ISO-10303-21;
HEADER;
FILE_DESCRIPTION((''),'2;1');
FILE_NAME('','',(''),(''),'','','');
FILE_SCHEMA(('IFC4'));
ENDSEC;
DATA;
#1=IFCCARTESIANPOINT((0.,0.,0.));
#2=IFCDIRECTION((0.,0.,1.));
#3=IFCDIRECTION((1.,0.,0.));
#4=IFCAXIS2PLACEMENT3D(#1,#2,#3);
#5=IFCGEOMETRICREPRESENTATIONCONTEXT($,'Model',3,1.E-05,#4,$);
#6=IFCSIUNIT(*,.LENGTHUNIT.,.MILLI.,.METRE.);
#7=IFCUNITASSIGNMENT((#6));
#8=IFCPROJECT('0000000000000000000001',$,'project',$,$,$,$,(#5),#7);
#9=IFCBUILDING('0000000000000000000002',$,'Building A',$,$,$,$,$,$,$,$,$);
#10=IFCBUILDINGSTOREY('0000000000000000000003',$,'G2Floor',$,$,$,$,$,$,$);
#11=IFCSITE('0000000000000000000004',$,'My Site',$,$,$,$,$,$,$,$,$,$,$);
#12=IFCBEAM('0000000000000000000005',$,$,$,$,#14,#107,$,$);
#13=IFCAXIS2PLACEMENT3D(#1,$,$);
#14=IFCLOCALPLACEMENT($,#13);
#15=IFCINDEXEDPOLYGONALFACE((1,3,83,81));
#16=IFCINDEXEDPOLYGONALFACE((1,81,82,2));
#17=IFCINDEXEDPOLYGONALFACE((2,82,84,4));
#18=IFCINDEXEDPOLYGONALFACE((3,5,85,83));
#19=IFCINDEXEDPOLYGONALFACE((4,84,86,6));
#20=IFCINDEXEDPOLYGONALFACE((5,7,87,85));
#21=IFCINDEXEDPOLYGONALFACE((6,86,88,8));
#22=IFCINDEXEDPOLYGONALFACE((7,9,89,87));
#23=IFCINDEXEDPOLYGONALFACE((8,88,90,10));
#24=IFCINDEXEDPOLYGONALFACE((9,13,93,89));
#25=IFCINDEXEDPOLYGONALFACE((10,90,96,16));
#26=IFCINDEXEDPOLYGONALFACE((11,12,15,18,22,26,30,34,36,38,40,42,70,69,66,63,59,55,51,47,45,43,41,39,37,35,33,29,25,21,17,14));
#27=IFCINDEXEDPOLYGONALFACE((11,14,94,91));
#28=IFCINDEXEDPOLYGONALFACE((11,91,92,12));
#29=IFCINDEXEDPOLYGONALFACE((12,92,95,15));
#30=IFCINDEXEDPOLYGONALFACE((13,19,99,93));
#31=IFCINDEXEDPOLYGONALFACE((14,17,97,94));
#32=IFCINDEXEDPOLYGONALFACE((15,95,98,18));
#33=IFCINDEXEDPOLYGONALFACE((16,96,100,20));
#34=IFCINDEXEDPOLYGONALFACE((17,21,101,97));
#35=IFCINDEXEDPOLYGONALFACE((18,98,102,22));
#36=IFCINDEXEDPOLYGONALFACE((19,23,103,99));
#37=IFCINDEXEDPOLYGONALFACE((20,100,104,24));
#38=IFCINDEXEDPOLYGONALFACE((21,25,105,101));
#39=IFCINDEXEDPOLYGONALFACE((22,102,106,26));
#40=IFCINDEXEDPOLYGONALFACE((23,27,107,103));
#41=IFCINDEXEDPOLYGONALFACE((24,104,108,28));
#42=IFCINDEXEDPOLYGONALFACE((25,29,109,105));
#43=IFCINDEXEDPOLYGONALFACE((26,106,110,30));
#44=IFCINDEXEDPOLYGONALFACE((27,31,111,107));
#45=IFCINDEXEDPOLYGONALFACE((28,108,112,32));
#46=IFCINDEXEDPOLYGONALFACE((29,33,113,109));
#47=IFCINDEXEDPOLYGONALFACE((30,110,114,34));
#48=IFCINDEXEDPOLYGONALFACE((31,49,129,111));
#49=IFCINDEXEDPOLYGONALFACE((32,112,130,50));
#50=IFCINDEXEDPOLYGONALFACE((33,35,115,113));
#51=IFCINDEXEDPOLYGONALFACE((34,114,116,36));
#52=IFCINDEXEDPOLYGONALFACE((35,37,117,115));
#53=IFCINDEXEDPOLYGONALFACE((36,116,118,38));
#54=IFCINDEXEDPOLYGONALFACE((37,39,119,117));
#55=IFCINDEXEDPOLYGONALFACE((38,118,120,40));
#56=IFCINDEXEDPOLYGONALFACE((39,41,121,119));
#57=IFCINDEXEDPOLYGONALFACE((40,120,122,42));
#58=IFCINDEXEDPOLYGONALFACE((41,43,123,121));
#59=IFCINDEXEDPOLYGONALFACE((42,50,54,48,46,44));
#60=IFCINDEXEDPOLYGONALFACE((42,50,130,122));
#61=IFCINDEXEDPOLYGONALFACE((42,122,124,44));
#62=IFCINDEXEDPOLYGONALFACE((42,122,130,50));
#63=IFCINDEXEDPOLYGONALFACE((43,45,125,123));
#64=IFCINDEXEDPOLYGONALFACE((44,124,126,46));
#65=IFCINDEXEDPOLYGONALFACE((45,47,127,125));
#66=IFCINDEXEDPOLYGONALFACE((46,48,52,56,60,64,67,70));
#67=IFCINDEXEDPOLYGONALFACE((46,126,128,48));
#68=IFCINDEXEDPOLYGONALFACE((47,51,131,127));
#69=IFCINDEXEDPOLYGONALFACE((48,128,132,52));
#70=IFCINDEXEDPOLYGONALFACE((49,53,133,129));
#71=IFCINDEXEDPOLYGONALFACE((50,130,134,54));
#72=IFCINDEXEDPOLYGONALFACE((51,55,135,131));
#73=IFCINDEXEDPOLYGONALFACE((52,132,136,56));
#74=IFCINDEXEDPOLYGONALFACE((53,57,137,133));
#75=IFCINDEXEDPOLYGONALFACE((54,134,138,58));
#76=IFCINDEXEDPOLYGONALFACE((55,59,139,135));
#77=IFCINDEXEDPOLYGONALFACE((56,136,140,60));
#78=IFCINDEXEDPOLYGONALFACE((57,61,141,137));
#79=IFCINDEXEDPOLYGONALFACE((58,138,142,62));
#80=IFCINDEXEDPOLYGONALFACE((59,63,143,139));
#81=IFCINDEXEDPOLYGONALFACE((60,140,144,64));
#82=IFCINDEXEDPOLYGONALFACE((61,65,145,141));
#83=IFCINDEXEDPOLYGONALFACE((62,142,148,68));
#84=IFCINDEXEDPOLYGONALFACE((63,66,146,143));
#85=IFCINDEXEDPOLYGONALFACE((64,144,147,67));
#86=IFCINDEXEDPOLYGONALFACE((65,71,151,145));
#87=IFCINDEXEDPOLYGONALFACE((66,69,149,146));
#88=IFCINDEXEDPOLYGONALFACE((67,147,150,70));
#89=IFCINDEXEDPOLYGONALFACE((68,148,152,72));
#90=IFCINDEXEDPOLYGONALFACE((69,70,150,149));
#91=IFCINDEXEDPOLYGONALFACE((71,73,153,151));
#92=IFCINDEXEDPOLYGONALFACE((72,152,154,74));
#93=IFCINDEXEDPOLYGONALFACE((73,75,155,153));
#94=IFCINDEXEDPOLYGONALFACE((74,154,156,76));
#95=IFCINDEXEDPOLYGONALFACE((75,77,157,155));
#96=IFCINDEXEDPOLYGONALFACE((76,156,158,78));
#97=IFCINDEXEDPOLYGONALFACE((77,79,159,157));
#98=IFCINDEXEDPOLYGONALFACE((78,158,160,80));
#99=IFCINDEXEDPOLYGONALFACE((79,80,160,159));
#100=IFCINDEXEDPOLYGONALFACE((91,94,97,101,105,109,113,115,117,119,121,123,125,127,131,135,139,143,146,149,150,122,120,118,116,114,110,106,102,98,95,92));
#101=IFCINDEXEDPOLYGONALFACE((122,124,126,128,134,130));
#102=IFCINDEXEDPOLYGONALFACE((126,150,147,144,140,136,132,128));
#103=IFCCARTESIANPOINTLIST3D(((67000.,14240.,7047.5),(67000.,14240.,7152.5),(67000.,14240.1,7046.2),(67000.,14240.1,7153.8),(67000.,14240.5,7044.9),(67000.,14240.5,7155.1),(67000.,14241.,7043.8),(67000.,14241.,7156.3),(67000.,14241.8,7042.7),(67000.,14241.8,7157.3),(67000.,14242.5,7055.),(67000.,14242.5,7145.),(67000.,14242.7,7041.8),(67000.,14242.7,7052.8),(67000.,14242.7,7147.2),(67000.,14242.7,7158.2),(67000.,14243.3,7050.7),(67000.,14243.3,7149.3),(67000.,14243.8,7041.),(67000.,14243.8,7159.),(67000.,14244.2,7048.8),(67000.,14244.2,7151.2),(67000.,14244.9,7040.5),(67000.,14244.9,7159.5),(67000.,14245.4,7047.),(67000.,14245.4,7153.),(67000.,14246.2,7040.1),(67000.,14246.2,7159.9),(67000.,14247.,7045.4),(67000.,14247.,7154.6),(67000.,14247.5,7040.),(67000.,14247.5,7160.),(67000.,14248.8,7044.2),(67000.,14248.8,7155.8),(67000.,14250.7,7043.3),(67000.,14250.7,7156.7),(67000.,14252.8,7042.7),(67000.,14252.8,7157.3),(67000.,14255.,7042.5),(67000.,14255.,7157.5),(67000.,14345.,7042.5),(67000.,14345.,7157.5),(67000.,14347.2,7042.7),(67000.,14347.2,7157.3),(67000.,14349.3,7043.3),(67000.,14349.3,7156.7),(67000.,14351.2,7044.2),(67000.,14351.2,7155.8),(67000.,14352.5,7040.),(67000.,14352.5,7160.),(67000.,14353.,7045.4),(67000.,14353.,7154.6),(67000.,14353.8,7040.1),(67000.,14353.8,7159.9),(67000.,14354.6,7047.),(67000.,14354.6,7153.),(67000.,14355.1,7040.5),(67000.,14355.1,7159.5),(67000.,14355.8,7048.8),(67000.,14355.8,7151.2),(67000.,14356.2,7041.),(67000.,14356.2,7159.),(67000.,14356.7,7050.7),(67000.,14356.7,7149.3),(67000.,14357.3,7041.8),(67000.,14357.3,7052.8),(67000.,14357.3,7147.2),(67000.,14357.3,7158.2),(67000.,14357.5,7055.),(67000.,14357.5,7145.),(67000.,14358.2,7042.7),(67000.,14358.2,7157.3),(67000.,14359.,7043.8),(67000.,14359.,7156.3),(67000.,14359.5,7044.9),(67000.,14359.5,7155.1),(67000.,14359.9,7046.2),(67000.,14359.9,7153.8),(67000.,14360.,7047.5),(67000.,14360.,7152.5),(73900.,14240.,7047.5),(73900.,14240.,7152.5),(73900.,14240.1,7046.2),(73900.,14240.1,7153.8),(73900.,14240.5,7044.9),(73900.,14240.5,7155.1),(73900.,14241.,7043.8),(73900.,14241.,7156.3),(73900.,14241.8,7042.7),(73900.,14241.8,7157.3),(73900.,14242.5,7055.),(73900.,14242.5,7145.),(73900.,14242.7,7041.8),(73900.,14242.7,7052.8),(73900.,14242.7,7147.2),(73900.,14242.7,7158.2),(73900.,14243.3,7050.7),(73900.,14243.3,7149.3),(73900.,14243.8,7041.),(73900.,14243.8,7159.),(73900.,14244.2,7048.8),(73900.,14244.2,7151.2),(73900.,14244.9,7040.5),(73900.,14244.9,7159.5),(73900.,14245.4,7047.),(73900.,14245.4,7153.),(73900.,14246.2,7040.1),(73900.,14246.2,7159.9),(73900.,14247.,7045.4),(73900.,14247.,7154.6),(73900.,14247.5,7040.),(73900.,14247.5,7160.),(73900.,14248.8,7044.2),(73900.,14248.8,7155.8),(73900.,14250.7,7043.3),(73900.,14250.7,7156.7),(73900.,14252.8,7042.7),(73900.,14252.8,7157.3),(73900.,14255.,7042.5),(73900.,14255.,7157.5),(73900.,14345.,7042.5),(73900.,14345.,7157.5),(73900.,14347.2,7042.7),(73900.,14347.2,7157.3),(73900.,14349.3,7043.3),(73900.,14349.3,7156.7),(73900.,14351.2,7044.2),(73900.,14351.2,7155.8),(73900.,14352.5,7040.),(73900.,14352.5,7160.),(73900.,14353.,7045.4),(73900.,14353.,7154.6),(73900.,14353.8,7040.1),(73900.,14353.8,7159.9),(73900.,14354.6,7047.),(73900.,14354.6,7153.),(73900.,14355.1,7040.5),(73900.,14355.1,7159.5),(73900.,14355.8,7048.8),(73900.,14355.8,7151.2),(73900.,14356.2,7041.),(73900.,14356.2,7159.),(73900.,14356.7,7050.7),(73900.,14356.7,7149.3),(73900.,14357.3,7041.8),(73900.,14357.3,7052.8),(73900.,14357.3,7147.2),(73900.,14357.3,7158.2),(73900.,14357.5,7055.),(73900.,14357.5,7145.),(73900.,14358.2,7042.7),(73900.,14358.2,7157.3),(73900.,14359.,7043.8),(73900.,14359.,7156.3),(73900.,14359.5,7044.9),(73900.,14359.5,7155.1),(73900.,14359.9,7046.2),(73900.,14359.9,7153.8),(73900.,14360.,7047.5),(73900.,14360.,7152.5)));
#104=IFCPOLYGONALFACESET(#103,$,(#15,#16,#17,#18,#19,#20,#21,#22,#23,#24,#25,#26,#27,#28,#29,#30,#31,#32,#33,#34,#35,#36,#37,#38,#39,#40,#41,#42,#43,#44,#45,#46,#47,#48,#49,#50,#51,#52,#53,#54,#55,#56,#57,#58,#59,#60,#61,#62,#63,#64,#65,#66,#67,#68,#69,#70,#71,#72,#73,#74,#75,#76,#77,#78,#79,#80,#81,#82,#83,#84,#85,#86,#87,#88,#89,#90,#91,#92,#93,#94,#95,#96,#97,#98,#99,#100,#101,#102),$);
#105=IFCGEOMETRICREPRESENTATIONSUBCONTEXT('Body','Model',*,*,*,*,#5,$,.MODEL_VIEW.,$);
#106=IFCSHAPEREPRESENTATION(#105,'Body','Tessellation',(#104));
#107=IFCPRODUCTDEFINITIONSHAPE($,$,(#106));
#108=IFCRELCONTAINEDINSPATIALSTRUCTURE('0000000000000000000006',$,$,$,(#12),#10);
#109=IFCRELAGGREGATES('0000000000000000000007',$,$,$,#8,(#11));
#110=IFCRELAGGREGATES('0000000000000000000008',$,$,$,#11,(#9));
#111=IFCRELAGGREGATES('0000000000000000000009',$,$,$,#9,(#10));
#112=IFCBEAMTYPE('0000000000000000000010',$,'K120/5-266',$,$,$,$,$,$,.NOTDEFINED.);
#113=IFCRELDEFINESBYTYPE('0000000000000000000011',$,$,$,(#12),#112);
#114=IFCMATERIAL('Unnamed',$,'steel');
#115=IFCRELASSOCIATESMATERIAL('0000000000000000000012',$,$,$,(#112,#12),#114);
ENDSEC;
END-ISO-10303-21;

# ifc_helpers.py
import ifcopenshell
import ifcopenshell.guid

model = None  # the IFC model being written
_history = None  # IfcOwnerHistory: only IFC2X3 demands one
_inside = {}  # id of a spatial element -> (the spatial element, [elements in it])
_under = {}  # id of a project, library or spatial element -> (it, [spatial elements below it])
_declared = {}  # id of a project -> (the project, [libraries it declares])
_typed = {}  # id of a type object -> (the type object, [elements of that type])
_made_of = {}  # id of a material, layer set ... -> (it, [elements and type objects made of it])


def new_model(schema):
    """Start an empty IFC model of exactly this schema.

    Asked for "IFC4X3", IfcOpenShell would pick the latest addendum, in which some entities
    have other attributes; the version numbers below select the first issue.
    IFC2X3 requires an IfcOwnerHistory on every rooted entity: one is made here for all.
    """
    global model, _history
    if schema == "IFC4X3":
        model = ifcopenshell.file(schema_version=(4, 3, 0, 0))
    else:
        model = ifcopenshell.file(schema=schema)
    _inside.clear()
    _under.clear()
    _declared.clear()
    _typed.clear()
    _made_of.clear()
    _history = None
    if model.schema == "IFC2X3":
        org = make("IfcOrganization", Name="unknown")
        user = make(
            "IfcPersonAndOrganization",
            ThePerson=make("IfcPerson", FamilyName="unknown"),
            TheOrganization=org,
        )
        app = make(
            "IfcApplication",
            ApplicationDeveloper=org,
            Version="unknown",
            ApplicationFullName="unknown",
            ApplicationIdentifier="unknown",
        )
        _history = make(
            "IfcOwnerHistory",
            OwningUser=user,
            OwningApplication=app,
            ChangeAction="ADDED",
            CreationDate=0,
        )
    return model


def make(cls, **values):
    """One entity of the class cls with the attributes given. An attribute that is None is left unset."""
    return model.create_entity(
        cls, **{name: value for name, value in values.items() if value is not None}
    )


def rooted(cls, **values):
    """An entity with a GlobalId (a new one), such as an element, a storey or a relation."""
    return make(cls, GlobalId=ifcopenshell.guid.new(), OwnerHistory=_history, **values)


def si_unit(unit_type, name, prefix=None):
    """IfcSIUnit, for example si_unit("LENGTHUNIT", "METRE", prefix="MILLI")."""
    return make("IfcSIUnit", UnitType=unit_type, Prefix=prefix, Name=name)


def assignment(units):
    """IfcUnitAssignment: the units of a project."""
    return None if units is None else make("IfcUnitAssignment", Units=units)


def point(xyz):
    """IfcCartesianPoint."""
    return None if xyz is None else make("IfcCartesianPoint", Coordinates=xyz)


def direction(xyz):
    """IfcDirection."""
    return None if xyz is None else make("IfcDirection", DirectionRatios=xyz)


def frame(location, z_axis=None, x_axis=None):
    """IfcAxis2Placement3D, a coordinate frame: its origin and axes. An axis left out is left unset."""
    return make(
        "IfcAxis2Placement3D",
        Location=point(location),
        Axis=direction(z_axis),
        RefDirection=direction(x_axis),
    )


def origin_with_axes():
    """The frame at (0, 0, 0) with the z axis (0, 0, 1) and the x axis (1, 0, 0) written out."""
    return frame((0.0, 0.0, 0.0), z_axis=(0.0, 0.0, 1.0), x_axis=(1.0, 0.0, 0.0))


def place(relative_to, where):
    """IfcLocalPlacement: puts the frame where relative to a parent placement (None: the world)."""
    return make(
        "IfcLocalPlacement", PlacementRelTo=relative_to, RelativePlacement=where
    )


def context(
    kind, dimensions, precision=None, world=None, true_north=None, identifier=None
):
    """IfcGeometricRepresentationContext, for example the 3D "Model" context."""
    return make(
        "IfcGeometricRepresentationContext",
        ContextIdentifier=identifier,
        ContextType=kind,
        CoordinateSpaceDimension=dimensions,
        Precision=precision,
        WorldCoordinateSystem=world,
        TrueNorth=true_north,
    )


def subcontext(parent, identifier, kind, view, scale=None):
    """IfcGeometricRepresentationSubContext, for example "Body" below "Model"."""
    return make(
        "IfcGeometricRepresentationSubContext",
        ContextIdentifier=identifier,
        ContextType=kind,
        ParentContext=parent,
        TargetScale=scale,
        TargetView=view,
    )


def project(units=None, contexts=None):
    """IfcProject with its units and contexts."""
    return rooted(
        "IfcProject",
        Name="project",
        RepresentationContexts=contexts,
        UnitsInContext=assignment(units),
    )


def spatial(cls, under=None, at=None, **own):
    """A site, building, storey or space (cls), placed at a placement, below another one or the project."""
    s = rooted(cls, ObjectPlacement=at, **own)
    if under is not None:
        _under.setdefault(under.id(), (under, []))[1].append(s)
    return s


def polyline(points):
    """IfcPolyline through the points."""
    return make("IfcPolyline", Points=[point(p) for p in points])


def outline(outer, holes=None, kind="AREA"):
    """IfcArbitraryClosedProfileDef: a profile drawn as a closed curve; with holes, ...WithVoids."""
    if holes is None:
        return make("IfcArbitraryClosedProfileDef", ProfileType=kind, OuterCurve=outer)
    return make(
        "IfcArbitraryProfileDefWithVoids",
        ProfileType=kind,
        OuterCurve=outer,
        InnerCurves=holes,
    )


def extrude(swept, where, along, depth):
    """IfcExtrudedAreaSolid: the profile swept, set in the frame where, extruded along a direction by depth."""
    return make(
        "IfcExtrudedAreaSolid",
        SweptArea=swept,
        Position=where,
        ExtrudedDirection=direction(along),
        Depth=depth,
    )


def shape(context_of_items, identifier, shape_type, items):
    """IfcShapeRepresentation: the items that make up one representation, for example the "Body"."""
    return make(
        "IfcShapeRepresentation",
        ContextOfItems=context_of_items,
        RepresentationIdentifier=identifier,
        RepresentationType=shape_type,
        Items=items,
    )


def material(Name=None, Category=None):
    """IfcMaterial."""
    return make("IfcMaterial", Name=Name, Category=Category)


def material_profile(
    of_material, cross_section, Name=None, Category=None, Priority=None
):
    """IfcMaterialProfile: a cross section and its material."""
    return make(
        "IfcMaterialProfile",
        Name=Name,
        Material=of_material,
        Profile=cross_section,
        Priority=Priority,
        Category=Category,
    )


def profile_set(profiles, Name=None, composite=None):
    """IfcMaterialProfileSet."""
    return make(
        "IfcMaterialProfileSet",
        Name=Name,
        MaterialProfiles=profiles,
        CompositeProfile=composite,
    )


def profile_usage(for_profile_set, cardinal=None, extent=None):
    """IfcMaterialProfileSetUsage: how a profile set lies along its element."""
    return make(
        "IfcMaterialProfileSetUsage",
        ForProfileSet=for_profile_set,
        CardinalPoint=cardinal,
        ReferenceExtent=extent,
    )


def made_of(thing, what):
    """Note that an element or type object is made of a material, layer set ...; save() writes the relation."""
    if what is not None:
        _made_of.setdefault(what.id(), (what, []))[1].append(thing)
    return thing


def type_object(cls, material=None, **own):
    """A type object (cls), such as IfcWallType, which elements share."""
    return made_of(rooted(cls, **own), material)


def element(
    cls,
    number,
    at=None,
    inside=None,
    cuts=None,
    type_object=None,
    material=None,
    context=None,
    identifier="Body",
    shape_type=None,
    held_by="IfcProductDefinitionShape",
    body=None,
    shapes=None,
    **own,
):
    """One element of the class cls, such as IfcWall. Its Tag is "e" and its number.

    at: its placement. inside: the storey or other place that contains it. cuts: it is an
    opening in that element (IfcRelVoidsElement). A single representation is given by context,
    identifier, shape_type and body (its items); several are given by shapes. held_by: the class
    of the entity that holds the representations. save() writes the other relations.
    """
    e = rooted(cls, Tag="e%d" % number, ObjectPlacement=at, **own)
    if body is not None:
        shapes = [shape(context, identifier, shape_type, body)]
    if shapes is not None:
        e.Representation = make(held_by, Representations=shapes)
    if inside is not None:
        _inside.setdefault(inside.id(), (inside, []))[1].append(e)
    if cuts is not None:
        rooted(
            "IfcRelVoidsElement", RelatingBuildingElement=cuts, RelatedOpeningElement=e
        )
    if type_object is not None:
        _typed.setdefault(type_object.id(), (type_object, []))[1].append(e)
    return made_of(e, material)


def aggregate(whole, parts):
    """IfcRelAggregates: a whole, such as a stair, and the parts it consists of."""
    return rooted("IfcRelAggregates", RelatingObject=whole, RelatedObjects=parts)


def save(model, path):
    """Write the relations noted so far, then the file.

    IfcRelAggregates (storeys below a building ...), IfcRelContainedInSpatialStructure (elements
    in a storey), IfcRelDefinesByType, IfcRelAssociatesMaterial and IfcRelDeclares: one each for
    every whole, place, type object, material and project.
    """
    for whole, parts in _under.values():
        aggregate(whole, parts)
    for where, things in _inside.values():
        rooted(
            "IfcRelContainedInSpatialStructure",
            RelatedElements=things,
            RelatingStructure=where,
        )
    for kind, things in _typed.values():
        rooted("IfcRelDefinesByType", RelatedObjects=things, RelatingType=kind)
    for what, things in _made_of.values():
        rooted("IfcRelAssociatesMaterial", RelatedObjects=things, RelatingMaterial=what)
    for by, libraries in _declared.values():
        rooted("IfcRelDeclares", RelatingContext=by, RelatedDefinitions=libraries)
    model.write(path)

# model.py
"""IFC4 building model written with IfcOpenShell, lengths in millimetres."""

from ifc_helpers import new_model, si_unit, frame, origin_with_axes, place, context, subcontext, project, spatial, polyline, outline, extrude, material, material_profile, profile_set, profile_usage, type_object, element, save


model = new_model("IFC4")

# Units and contexts
model_context = context("Model", 3, precision=1e-05, world=origin_with_axes())
body_context = subcontext(model_context, "Body", "Model", "MODEL_VIEW")
ifc_project = project(units=[si_unit("LENGTHUNIT", "METRE", prefix="MILLI")], contexts=[model_context])

# Site, building, storey
site = spatial("IfcSite", under=ifc_project, Name="My Site")
building = spatial("IfcBuilding", under=site, Name="Building A")
storey = spatial("IfcBuildingStorey", under=building, Name="G2Floor")

# Beam
ifc_material_1 = material(Name="Unnamed", Category="steel")
ifc_material_profile_1 = material_profile(ifc_material_1, outline(polyline([(-52.5, -60.0), (52.5, -60.0), (52.5, -60.0), (53.8, -59.9), (53.8, -59.9), (55.1, -59.5), (55.1, -59.5), (56.2, -59.0), (56.2, -59.0), (57.3, -58.2), (57.3, -58.2), (58.2, -57.3), (58.2, -57.3), (59.0, -56.2), (59.0, -56.2), (59.5, -55.1), (59.5, -55.1), (59.9, -53.8), (59.9, -53.8), (60.0, -52.5), (60.0, -52.5), (60.0, 52.5), (60.0, 52.5), (59.9, 53.8), (59.9, 53.8), (59.5, 55.1), (59.5, 55.1), (59.0, 56.2), (59.0, 56.2), (58.2, 57.3), (58.2, 57.3), (57.3, 58.2), (57.3, 58.2), (56.2, 59.0), (56.2, 59.0), (55.1, 59.5), (55.1, 59.5), (53.8, 59.9), (53.8, 59.9), (52.5, 60.0), (52.5, 60.0), (-52.5, 60.0), (-52.5, 60.0), (-53.8, 59.9), (-53.8, 59.9), (-55.1, 59.5), (-55.1, 59.5), (-56.2, 59.0), (-56.2, 59.0), (-57.3, 58.2), (-57.3, 58.2), (-58.2, 57.3), (-58.2, 57.3), (-59.0, 56.2), (-59.0, 56.2), (-59.5, 55.1), (-59.5, 55.1), (-59.9, 53.8), (-59.9, 53.8), (-60.0, 52.5), (-60.0, 52.5), (-60.0, -52.5), (-60.0, -52.5), (-59.9, -53.8), (-59.9, -53.8), (-59.5, -55.1), (-59.5, -55.1), (-59.0, -56.2), (-59.0, -56.2), (-58.2, -57.3), (-58.2, -57.3), (-57.3, -58.2), (-57.3, -58.2), (-56.2, -59.0), (-56.2, -59.0), (-55.1, -59.5), (-55.1, -59.5), (-53.8, -59.9), (-53.8, -59.9), (-52.5, -60.0), (-52.5, -60.0), (-45.0, -57.5), (-45.0, -57.5), (45.0, -57.5), (45.0, -57.5), (47.2, -57.3), (47.2, -57.3), (49.3, -56.7), (49.3, -56.7), (51.2, -55.8), (51.2, -55.8), (53.0, -54.6), (53.0, -54.6), (54.6, -53.0), (54.6, -53.0), (55.8, -51.2), (55.8, -51.2), (56.7, -49.3), (56.7, -49.3), (57.3, -47.2), (57.3, -47.2), (57.5, -45.0), (57.5, -45.0), (57.5, 45.0), (57.5, 45.0), (57.3, 47.2), (57.3, 47.2), (56.7, 49.3), (56.7, 49.3), (55.8, 51.2), (55.8, 51.2), (54.6, 53.0), (54.6, 53.0), (53.0, 54.6), (53.0, 54.6), (51.2, 55.8), (51.2, 55.8), (49.3, 56.7), (49.3, 56.7), (47.2, 57.3), (47.2, 57.3), (45.0, 57.5), (45.0, 57.5), (-45.0, 57.5), (-45.0, 57.5), (-47.2, 57.3), (-47.2, 57.3), (-49.3, 56.7), (-49.3, 56.7), (-51.2, 55.8), (-51.2, 55.8), (-53.0, 54.6), (-53.0, 54.6), (-54.6, 53.0), (-54.6, 53.0), (-55.8, 51.2), (-55.8, 51.2), (-56.7, 49.3), (-56.7, 49.3), (-57.3, 47.2), (-57.3, 47.2), (-57.5, 45.0), (-57.5, 45.0), (-57.5, -45.0), (-57.5, -45.0), (-57.3, -47.2), (-57.3, -47.2), (-56.7, -49.3), (-56.7, -49.3), (-55.8, -51.2), (-55.8, -51.2), (-54.6, -53.0), (-54.6, -53.0), (-53.0, -54.6), (-53.0, -54.6), (-51.2, -55.8), (-51.2, -55.8), (-49.3, -56.7), (-49.3, -56.7), (-47.2, -57.3), (-47.2, -57.3), (-45.0, -57.5), (-45.0, -57.5), (-52.5, -60.0)])))
ifc_profile_set_1 = profile_set([ifc_material_profile_1], Name="K120/5-266")
ifc_profile_usage_1 = profile_usage(ifc_profile_set_1)
beam_type_1 = type_object("IfcBeamType", Name="K120/5-266", PredefinedType="NOTDEFINED", material=ifc_profile_set_1)
beam_1_placement = place(None, frame((67000.0, 14300.0, 7100.0), z_axis=(1.0, 0.0, 0.0), x_axis=(0.0, -1.0, 0.0)))
element("IfcBeam", 1, at=beam_1_placement, inside=storey, type_object=beam_type_1, material=ifc_profile_usage_1, context=body_context, shape_type="SweptSolid", body=[
    extrude(outline(polyline([(-52.5, -60.0), (52.5, -60.0), (52.5, -60.0), (53.8, -59.9), (53.8, -59.9), (55.1, -59.5), (55.1, -59.5), (56.2, -59.0), (56.2, -59.0), (57.3, -58.2), (57.3, -58.2), (58.2, -57.3), (58.2, -57.3), (59.0, -56.2), (59.0, -56.2), (59.5, -55.1), (59.5, -55.1), (59.9, -53.8), (59.9, -53.8), (60.0, -52.5), (60.0, -52.5), (60.0, 52.5), (60.0, 52.5), (59.9, 53.8), (59.9, 53.8), (59.5, 55.1), (59.5, 55.1), (59.0, 56.2), (59.0, 56.2), (58.2, 57.3), (58.2, 57.3), (57.3, 58.2), (57.3, 58.2), (56.2, 59.0), (56.2, 59.0), (55.1, 59.5), (55.1, 59.5), (53.8, 59.9), (53.8, 59.9), (52.5, 60.0), (52.5, 60.0), (-52.5, 60.0), (-52.5, 60.0), (-53.8, 59.9), (-53.8, 59.9), (-55.1, 59.5), (-55.1, 59.5), (-56.2, 59.0), (-56.2, 59.0), (-57.3, 58.2), (-57.3, 58.2), (-58.2, 57.3), (-58.2, 57.3), (-59.0, 56.2), (-59.0, 56.2), (-59.5, 55.1), (-59.5, 55.1), (-59.9, 53.8), (-59.9, 53.8), (-60.0, 52.5), (-60.0, 52.5), (-60.0, -52.5), (-60.0, -52.5), (-59.9, -53.8), (-59.9, -53.8), (-59.5, -55.1), (-59.5, -55.1), (-59.0, -56.2), (-59.0, -56.2), (-58.2, -57.3), (-58.2, -57.3), (-57.3, -58.2), (-57.3, -58.2), (-56.2, -59.0), (-56.2, -59.0), (-55.1, -59.5), (-55.1, -59.5), (-53.8, -59.9), (-53.8, -59.9), (-52.5, -60.0), (-52.5, -60.0), (-45.0, -57.5), (-45.0, -57.5), (45.0, -57.5), (45.0, -57.5), (47.2, -57.3), (47.2, -57.3), (49.3, -56.7), (49.3, -56.7), (51.2, -55.8), (51.2, -55.8), (53.0, -54.6), (53.0, -54.6), (54.6, -53.0), (54.6, -53.0), (55.8, -51.2), (55.8, -51.2), (56.7, -49.3), (56.7, -49.3), (57.3, -47.2), (57.3, -47.2), (57.5, -45.0), (57.5, -45.0), (57.5, 45.0), (57.5, 45.0), (57.3, 47.2), (57.3, 47.2), (56.7, 49.3), (56.7, 49.3), (55.8, 51.2), (55.8, 51.2), (54.6, 53.0), (54.6, 53.0), (53.0, 54.6), (53.0, 54.6), (51.2, 55.8), (51.2, 55.8), (49.3, 56.7), (49.3, 56.7), (47.2, 57.3), (47.2, 57.3), (45.0, 57.5), (45.0, 57.5), (-45.0, 57.5), (-45.0, 57.5), (-47.2, 57.3), (-47.2, 57.3), (-49.3, 56.7), (-49.3, 56.7), (-51.2, 55.8), (-51.2, 55.8), (-53.0, 54.6), (-53.0, 54.6), (-54.6, 53.0), (-54.6, 53.0), (-55.8, 51.2), (-55.8, 51.2), (-56.7, 49.3), (-56.7, 49.3), (-57.3, 47.2), (-57.3, 47.2), (-57.5, 45.0), (-57.5, 45.0), (-57.5, -45.0), (-57.5, -45.0), (-57.3, -47.2), (-57.3, -47.2), (-56.7, -49.3), (-56.7, -49.3), (-55.8, -51.2), (-55.8, -51.2), (-54.6, -53.0), (-54.6, -53.0), (-53.0, -54.6), (-53.0, -54.6), (-51.2, -55.8), (-51.2, -55.8), (-49.3, -56.7), (-49.3, -56.7), (-47.2, -57.3), (-47.2, -57.3), (-45.0, -57.5), (-45.0, -57.5), (-52.5, -60.0)])), origin_with_axes(), (0.0, 0.0, 1.0), 6900.0),
])

save(model, "model.ifc")
